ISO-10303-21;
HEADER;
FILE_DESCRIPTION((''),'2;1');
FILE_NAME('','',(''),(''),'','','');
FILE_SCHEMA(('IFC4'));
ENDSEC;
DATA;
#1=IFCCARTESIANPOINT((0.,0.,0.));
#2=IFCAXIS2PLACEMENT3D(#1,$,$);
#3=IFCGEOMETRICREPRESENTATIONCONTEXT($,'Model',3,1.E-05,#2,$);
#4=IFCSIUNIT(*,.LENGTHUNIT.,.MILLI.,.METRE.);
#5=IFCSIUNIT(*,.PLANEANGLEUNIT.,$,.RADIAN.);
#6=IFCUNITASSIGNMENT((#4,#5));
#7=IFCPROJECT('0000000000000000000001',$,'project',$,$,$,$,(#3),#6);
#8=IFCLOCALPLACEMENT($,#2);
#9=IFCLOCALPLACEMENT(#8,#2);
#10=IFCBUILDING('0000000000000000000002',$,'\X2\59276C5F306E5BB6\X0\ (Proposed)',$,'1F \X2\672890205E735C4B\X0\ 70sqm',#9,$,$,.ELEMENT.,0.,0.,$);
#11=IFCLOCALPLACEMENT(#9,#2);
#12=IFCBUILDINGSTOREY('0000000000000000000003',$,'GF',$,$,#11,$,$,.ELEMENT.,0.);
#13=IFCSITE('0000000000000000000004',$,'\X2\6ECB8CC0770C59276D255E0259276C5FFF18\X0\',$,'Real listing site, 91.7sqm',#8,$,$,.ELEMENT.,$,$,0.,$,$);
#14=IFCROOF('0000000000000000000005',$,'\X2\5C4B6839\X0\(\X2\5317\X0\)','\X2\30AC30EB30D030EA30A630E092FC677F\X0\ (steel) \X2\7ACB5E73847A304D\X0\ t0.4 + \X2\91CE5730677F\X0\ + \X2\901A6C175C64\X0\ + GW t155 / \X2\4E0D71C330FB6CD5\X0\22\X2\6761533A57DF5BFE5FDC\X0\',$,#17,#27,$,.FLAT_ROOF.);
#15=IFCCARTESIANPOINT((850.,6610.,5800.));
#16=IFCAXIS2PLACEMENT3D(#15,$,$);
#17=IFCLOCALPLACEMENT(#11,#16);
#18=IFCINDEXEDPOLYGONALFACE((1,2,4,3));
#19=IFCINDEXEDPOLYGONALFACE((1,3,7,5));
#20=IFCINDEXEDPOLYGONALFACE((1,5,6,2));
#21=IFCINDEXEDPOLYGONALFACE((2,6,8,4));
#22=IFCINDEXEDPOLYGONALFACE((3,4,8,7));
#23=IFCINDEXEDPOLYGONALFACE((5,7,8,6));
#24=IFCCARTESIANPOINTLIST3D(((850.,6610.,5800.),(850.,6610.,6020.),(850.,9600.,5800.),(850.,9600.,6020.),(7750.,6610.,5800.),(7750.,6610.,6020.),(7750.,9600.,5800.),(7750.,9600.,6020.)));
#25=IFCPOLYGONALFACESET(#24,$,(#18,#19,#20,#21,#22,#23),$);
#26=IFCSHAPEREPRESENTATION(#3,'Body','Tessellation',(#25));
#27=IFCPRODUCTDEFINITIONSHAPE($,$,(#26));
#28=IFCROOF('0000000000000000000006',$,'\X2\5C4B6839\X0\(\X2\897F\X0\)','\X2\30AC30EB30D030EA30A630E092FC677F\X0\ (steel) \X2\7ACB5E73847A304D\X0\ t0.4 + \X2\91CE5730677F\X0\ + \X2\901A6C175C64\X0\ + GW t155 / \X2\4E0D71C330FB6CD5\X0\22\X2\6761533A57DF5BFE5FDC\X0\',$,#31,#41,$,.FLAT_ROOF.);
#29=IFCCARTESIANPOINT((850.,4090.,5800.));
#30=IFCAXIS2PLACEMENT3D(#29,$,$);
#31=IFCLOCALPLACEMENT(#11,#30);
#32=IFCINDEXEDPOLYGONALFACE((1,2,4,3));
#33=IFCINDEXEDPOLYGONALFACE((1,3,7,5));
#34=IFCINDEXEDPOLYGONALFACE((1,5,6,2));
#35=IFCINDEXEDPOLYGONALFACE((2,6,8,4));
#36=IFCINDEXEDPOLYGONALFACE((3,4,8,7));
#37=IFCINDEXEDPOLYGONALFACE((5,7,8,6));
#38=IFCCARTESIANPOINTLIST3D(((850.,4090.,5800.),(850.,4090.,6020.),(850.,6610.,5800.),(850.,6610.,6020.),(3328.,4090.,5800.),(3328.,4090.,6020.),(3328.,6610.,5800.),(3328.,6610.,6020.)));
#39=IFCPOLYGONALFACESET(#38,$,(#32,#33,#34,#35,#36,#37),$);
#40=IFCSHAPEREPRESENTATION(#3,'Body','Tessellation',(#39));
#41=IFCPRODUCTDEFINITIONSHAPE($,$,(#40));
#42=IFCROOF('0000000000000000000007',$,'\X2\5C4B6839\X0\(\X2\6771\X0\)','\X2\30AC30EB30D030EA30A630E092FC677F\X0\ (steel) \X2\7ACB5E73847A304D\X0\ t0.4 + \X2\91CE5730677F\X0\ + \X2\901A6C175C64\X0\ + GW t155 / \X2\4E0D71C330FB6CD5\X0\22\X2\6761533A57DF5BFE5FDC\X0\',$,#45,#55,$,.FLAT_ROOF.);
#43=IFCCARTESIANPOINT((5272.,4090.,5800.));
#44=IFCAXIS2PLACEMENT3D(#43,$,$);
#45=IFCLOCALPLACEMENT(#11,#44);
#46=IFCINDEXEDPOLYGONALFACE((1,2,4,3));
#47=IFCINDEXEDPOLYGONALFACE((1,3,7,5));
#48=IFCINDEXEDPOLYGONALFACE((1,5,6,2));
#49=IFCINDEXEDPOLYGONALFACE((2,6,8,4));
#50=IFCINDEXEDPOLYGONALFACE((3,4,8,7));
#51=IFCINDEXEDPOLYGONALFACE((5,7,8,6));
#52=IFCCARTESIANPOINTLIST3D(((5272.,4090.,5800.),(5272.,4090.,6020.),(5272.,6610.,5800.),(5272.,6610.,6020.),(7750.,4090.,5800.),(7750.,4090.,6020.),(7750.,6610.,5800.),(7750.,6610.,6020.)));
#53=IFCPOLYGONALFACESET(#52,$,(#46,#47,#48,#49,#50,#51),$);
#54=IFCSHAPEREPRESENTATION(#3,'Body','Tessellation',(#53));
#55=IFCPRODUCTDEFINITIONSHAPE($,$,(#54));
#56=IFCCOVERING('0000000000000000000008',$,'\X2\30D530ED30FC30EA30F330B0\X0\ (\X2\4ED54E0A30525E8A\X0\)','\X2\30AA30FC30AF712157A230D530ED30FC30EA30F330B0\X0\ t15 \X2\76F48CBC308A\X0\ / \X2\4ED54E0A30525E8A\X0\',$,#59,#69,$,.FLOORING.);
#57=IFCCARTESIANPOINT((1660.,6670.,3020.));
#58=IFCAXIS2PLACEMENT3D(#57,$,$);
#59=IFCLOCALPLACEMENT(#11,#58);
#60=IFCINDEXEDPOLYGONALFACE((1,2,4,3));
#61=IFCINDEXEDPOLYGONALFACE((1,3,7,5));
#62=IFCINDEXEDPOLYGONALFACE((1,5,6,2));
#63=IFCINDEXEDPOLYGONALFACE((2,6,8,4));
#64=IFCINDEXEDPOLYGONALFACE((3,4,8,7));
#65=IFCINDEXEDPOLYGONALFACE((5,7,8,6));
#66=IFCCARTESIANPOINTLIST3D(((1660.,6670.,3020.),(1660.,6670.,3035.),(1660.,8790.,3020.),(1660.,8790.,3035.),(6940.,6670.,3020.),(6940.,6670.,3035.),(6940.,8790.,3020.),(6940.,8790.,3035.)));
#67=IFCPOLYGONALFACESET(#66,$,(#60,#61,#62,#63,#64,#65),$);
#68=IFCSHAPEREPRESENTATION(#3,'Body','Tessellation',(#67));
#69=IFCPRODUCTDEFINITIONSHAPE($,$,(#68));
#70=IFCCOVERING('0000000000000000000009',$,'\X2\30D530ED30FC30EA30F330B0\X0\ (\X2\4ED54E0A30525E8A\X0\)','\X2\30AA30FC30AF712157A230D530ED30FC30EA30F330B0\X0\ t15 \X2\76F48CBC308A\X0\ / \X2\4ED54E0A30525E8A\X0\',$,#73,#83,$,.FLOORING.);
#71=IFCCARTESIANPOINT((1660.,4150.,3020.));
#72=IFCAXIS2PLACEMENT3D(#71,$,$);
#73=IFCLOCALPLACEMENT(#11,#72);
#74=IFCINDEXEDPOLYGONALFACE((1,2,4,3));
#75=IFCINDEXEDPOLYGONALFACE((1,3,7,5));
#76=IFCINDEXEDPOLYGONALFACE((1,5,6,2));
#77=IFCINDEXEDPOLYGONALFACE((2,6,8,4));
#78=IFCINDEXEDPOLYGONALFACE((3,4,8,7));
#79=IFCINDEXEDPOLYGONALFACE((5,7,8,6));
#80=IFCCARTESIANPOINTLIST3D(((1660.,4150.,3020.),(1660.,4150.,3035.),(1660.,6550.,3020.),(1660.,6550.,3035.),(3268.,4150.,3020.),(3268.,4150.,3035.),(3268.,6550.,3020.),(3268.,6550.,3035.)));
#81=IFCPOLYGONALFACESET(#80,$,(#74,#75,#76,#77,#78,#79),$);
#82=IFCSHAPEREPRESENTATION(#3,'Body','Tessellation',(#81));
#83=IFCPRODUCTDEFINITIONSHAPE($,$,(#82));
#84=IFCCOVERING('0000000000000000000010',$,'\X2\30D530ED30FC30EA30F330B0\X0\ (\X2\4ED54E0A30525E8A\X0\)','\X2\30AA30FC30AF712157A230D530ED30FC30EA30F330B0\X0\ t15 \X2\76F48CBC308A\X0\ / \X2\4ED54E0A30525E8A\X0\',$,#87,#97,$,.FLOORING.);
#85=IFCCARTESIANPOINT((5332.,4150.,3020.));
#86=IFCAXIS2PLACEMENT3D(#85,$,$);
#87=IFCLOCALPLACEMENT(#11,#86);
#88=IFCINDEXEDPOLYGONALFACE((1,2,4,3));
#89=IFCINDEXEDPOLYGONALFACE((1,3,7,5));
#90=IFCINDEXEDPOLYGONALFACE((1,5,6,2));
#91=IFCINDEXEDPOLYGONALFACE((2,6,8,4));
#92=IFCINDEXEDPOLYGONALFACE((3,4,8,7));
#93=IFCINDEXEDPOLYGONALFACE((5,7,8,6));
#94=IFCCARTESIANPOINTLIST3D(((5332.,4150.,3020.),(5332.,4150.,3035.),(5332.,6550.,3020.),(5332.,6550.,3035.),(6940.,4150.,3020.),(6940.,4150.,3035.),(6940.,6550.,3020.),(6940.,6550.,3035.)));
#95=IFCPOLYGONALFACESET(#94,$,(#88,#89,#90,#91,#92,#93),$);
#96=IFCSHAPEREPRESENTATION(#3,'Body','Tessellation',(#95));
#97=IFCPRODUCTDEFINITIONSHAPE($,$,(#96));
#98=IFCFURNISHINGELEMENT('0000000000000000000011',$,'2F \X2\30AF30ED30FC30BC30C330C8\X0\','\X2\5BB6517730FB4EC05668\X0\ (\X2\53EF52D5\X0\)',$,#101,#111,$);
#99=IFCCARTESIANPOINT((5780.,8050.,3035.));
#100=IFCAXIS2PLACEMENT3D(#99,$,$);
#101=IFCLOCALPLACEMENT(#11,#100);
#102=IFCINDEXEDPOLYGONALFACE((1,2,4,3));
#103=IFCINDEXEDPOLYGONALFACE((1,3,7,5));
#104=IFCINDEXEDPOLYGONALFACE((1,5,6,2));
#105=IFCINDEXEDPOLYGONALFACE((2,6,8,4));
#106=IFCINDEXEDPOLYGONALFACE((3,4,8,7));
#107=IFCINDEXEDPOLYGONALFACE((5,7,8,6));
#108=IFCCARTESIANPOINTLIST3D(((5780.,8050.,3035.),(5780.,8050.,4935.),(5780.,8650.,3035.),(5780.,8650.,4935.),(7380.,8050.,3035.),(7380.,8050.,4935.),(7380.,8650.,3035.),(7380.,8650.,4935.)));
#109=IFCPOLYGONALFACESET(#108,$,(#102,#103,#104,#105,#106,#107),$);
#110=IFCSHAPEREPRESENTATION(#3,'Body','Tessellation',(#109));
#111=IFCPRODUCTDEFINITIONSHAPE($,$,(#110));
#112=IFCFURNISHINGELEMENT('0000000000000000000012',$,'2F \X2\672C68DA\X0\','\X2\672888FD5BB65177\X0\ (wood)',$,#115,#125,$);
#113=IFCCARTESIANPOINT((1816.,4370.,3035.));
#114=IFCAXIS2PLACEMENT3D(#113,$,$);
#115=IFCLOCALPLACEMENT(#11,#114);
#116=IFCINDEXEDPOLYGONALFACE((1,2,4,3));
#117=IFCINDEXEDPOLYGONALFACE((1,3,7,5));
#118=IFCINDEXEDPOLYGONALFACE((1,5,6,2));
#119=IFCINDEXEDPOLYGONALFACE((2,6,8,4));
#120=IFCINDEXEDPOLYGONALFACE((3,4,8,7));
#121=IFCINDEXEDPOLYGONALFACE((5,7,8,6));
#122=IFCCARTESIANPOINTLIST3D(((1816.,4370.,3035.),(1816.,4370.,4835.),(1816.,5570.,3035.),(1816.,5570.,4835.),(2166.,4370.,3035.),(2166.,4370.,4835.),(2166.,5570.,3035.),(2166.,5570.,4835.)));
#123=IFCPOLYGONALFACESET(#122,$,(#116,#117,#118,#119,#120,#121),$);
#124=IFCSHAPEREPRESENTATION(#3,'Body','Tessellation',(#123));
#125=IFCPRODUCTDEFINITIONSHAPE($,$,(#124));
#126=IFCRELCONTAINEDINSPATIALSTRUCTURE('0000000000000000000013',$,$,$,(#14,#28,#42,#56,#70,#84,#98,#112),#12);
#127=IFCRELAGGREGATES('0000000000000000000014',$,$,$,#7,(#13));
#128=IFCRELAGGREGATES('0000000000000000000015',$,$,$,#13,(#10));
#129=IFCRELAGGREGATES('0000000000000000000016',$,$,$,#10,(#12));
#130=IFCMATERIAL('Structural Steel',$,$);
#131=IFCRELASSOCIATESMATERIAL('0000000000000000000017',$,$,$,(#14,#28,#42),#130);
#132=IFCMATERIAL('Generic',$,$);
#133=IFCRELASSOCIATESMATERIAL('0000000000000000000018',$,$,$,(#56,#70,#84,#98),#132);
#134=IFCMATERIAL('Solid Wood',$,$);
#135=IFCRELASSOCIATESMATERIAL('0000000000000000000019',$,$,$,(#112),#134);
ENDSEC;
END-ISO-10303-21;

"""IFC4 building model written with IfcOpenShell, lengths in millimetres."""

from ifc_helpers import new_model, si_unit, frame, frame_2d, origin, place, context, project, spatial, rectangle, extrude, material, element, save


model = new_model("IFC4")

# Units and contexts
model_context = context("Model", 3, precision=1e-05, world=origin())
ifc_project = project(units=[si_unit("LENGTHUNIT", "METRE", prefix="MILLI"), si_unit("PLANEANGLEUNIT", "RADIAN")], contexts=[model_context])

# Site, building, storey
site_placement = place(None, origin())
site = spatial("IfcSite", under=ifc_project, at=site_placement, Name="滋賀県大津市大江８", ObjectType="Real listing site, 91.7sqm", CompositionType="ELEMENT", RefElevation=0.0)
building_placement = place(site_placement, origin())
building = spatial("IfcBuilding", under=site, at=building_placement, Name="大江の家 (Proposed)", ObjectType="1F 木造平屋 70sqm", CompositionType="ELEMENT", ElevationOfRefHeight=0.0, ElevationOfTerrain=0.0)
storey_placement = place(building_placement, origin())
storey = spatial("IfcBuildingStorey", under=building, at=storey_placement, Name="GF", CompositionType="ELEMENT", Elevation=0.0)

# Shared definitions
ifc_material_1 = material(Name="Solid Wood")

# Shared definitions
ifc_material_2 = material(Name="Generic")

# Roofs
ifc_material_3 = material(Name="Structural Steel")
for number, where, name in (
    (1, (850.0, 6610.0, 5800.0), "屋根(北)"),
):
    element("IfcRoof", number, at=place(storey_placement, frame(where)), inside=storey, material=ifc_material_3, Name=name, Description="ガルバリウム鋼板 (steel) 立平葺き t0.4 + 野地板 + 通気層 + GW t155 / 不燃・法22条区域対応", PredefinedType="FLAT_ROOF", context=model_context, shape_type="SweptSolid", body=[
        extrude(rectangle(XDim=6900.0, YDim=2990.0, at=frame_2d((3450.0, 1495.0))), frame((850.0, 6610.0, 5800.0)), (0.0, 0.0, 1.0), 220.0),
    ])
roof_1_placement = place(storey_placement, frame((850.0, 4090.0, 5800.0)))
element("IfcRoof", 2, at=roof_1_placement, inside=storey, material=ifc_material_3, Name="屋根(西)", Description="ガルバリウム鋼板 (steel) 立平葺き t0.4 + 野地板 + 通気層 + GW t155 / 不燃・法22条区域対応", PredefinedType="FLAT_ROOF", context=model_context, shape_type="SweptSolid", body=[
    extrude(rectangle(XDim=2478.0, YDim=2520.0, at=frame_2d((1239.0, 1260.0))), frame((850.0, 4090.0, 5800.0)), (0.0, 0.0, 1.0), 220.0),
])
roof_2_placement = place(storey_placement, frame((5272.0, 4090.0, 5800.0)))
element("IfcRoof", 3, at=roof_2_placement, inside=storey, material=ifc_material_3, Name="屋根(東)", Description="ガルバリウム鋼板 (steel) 立平葺き t0.4 + 野地板 + 通気層 + GW t155 / 不燃・法22条区域対応", PredefinedType="FLAT_ROOF", context=model_context, shape_type="SweptSolid", body=[
    extrude(rectangle(XDim=2478.0, YDim=2520.0, at=frame_2d((1239.0, 1260.0))), frame((5272.0, 4090.0, 5800.0)), (0.0, 0.0, 1.0), 220.0),
])

# Coverings
covering_1_placement = place(storey_placement, frame((1660.0, 6670.0, 3020.0)))
element("IfcCovering", 4, at=covering_1_placement, inside=storey, material=ifc_material_2, Name="フローリング (仕上げ床)", Description="オーク無垢フローリング t15 直貼り / 仕上げ床", PredefinedType="FLOORING", context=model_context, shape_type="SweptSolid", body=[
    extrude(rectangle(XDim=5280.0, YDim=2120.0, at=frame_2d((2640.0, 1060.0))), frame((1660.0, 6670.0, 3020.0)), (0.0, 0.0, 1.0), 15.0),
])
covering_2_placement = place(storey_placement, frame((1660.0, 4150.0, 3020.0)))
element("IfcCovering", 5, at=covering_2_placement, inside=storey, material=ifc_material_2, Name="フローリング (仕上げ床)", Description="オーク無垢フローリング t15 直貼り / 仕上げ床", PredefinedType="FLOORING", context=model_context, shape_type="SweptSolid", body=[
    extrude(rectangle(XDim=1608.0, YDim=2400.0, at=frame_2d((804.0, 1200.0))), frame((1660.0, 4150.0, 3020.0)), (0.0, 0.0, 1.0), 15.0),
])
covering_3_placement = place(storey_placement, frame((5332.0, 4150.0, 3020.0)))
element("IfcCovering", 6, at=covering_3_placement, inside=storey, material=ifc_material_2, Name="フローリング (仕上げ床)", Description="オーク無垢フローリング t15 直貼り / 仕上げ床", PredefinedType="FLOORING", context=model_context, shape_type="SweptSolid", body=[
    extrude(rectangle(XDim=1608.0, YDim=2400.0, at=frame_2d((804.0, 1200.0))), frame((5332.0, 4150.0, 3020.0)), (0.0, 0.0, 1.0), 15.0),
])

# Furnishing elements
furnishing_1_placement = place(storey_placement, frame((5780.0, 8050.0, 3035.0)))
element("IfcFurnishingElement", 7, at=furnishing_1_placement, inside=storey, material=ifc_material_2, Name="2F クローゼット", Description="家具・什器 (可動)", context=model_context, shape_type="SweptSolid", body=[
    extrude(rectangle(XDim=1600.0, YDim=600.0, at=frame_2d((800.0, 300.0))), frame((5780.0, 8050.0, 3035.0)), (0.0, 0.0, 1.0), 1900.0),
])
furnishing_2_placement = place(storey_placement, frame((1816.0, 4370.0, 3035.0)))
element("IfcFurnishingElement", 8, at=furnishing_2_placement, inside=storey, material=ifc_material_1, Name="2F 本棚", Description="木製家具 (wood)", context=model_context, shape_type="SweptSolid", body=[
    extrude(rectangle(XDim=350.0, YDim=1200.0, at=frame_2d((175.0, 600.0))), frame((1816.0, 4370.0, 3035.0)), (0.0, 0.0, 1.0), 1800.0),
])

save(model, "model.ifc")
